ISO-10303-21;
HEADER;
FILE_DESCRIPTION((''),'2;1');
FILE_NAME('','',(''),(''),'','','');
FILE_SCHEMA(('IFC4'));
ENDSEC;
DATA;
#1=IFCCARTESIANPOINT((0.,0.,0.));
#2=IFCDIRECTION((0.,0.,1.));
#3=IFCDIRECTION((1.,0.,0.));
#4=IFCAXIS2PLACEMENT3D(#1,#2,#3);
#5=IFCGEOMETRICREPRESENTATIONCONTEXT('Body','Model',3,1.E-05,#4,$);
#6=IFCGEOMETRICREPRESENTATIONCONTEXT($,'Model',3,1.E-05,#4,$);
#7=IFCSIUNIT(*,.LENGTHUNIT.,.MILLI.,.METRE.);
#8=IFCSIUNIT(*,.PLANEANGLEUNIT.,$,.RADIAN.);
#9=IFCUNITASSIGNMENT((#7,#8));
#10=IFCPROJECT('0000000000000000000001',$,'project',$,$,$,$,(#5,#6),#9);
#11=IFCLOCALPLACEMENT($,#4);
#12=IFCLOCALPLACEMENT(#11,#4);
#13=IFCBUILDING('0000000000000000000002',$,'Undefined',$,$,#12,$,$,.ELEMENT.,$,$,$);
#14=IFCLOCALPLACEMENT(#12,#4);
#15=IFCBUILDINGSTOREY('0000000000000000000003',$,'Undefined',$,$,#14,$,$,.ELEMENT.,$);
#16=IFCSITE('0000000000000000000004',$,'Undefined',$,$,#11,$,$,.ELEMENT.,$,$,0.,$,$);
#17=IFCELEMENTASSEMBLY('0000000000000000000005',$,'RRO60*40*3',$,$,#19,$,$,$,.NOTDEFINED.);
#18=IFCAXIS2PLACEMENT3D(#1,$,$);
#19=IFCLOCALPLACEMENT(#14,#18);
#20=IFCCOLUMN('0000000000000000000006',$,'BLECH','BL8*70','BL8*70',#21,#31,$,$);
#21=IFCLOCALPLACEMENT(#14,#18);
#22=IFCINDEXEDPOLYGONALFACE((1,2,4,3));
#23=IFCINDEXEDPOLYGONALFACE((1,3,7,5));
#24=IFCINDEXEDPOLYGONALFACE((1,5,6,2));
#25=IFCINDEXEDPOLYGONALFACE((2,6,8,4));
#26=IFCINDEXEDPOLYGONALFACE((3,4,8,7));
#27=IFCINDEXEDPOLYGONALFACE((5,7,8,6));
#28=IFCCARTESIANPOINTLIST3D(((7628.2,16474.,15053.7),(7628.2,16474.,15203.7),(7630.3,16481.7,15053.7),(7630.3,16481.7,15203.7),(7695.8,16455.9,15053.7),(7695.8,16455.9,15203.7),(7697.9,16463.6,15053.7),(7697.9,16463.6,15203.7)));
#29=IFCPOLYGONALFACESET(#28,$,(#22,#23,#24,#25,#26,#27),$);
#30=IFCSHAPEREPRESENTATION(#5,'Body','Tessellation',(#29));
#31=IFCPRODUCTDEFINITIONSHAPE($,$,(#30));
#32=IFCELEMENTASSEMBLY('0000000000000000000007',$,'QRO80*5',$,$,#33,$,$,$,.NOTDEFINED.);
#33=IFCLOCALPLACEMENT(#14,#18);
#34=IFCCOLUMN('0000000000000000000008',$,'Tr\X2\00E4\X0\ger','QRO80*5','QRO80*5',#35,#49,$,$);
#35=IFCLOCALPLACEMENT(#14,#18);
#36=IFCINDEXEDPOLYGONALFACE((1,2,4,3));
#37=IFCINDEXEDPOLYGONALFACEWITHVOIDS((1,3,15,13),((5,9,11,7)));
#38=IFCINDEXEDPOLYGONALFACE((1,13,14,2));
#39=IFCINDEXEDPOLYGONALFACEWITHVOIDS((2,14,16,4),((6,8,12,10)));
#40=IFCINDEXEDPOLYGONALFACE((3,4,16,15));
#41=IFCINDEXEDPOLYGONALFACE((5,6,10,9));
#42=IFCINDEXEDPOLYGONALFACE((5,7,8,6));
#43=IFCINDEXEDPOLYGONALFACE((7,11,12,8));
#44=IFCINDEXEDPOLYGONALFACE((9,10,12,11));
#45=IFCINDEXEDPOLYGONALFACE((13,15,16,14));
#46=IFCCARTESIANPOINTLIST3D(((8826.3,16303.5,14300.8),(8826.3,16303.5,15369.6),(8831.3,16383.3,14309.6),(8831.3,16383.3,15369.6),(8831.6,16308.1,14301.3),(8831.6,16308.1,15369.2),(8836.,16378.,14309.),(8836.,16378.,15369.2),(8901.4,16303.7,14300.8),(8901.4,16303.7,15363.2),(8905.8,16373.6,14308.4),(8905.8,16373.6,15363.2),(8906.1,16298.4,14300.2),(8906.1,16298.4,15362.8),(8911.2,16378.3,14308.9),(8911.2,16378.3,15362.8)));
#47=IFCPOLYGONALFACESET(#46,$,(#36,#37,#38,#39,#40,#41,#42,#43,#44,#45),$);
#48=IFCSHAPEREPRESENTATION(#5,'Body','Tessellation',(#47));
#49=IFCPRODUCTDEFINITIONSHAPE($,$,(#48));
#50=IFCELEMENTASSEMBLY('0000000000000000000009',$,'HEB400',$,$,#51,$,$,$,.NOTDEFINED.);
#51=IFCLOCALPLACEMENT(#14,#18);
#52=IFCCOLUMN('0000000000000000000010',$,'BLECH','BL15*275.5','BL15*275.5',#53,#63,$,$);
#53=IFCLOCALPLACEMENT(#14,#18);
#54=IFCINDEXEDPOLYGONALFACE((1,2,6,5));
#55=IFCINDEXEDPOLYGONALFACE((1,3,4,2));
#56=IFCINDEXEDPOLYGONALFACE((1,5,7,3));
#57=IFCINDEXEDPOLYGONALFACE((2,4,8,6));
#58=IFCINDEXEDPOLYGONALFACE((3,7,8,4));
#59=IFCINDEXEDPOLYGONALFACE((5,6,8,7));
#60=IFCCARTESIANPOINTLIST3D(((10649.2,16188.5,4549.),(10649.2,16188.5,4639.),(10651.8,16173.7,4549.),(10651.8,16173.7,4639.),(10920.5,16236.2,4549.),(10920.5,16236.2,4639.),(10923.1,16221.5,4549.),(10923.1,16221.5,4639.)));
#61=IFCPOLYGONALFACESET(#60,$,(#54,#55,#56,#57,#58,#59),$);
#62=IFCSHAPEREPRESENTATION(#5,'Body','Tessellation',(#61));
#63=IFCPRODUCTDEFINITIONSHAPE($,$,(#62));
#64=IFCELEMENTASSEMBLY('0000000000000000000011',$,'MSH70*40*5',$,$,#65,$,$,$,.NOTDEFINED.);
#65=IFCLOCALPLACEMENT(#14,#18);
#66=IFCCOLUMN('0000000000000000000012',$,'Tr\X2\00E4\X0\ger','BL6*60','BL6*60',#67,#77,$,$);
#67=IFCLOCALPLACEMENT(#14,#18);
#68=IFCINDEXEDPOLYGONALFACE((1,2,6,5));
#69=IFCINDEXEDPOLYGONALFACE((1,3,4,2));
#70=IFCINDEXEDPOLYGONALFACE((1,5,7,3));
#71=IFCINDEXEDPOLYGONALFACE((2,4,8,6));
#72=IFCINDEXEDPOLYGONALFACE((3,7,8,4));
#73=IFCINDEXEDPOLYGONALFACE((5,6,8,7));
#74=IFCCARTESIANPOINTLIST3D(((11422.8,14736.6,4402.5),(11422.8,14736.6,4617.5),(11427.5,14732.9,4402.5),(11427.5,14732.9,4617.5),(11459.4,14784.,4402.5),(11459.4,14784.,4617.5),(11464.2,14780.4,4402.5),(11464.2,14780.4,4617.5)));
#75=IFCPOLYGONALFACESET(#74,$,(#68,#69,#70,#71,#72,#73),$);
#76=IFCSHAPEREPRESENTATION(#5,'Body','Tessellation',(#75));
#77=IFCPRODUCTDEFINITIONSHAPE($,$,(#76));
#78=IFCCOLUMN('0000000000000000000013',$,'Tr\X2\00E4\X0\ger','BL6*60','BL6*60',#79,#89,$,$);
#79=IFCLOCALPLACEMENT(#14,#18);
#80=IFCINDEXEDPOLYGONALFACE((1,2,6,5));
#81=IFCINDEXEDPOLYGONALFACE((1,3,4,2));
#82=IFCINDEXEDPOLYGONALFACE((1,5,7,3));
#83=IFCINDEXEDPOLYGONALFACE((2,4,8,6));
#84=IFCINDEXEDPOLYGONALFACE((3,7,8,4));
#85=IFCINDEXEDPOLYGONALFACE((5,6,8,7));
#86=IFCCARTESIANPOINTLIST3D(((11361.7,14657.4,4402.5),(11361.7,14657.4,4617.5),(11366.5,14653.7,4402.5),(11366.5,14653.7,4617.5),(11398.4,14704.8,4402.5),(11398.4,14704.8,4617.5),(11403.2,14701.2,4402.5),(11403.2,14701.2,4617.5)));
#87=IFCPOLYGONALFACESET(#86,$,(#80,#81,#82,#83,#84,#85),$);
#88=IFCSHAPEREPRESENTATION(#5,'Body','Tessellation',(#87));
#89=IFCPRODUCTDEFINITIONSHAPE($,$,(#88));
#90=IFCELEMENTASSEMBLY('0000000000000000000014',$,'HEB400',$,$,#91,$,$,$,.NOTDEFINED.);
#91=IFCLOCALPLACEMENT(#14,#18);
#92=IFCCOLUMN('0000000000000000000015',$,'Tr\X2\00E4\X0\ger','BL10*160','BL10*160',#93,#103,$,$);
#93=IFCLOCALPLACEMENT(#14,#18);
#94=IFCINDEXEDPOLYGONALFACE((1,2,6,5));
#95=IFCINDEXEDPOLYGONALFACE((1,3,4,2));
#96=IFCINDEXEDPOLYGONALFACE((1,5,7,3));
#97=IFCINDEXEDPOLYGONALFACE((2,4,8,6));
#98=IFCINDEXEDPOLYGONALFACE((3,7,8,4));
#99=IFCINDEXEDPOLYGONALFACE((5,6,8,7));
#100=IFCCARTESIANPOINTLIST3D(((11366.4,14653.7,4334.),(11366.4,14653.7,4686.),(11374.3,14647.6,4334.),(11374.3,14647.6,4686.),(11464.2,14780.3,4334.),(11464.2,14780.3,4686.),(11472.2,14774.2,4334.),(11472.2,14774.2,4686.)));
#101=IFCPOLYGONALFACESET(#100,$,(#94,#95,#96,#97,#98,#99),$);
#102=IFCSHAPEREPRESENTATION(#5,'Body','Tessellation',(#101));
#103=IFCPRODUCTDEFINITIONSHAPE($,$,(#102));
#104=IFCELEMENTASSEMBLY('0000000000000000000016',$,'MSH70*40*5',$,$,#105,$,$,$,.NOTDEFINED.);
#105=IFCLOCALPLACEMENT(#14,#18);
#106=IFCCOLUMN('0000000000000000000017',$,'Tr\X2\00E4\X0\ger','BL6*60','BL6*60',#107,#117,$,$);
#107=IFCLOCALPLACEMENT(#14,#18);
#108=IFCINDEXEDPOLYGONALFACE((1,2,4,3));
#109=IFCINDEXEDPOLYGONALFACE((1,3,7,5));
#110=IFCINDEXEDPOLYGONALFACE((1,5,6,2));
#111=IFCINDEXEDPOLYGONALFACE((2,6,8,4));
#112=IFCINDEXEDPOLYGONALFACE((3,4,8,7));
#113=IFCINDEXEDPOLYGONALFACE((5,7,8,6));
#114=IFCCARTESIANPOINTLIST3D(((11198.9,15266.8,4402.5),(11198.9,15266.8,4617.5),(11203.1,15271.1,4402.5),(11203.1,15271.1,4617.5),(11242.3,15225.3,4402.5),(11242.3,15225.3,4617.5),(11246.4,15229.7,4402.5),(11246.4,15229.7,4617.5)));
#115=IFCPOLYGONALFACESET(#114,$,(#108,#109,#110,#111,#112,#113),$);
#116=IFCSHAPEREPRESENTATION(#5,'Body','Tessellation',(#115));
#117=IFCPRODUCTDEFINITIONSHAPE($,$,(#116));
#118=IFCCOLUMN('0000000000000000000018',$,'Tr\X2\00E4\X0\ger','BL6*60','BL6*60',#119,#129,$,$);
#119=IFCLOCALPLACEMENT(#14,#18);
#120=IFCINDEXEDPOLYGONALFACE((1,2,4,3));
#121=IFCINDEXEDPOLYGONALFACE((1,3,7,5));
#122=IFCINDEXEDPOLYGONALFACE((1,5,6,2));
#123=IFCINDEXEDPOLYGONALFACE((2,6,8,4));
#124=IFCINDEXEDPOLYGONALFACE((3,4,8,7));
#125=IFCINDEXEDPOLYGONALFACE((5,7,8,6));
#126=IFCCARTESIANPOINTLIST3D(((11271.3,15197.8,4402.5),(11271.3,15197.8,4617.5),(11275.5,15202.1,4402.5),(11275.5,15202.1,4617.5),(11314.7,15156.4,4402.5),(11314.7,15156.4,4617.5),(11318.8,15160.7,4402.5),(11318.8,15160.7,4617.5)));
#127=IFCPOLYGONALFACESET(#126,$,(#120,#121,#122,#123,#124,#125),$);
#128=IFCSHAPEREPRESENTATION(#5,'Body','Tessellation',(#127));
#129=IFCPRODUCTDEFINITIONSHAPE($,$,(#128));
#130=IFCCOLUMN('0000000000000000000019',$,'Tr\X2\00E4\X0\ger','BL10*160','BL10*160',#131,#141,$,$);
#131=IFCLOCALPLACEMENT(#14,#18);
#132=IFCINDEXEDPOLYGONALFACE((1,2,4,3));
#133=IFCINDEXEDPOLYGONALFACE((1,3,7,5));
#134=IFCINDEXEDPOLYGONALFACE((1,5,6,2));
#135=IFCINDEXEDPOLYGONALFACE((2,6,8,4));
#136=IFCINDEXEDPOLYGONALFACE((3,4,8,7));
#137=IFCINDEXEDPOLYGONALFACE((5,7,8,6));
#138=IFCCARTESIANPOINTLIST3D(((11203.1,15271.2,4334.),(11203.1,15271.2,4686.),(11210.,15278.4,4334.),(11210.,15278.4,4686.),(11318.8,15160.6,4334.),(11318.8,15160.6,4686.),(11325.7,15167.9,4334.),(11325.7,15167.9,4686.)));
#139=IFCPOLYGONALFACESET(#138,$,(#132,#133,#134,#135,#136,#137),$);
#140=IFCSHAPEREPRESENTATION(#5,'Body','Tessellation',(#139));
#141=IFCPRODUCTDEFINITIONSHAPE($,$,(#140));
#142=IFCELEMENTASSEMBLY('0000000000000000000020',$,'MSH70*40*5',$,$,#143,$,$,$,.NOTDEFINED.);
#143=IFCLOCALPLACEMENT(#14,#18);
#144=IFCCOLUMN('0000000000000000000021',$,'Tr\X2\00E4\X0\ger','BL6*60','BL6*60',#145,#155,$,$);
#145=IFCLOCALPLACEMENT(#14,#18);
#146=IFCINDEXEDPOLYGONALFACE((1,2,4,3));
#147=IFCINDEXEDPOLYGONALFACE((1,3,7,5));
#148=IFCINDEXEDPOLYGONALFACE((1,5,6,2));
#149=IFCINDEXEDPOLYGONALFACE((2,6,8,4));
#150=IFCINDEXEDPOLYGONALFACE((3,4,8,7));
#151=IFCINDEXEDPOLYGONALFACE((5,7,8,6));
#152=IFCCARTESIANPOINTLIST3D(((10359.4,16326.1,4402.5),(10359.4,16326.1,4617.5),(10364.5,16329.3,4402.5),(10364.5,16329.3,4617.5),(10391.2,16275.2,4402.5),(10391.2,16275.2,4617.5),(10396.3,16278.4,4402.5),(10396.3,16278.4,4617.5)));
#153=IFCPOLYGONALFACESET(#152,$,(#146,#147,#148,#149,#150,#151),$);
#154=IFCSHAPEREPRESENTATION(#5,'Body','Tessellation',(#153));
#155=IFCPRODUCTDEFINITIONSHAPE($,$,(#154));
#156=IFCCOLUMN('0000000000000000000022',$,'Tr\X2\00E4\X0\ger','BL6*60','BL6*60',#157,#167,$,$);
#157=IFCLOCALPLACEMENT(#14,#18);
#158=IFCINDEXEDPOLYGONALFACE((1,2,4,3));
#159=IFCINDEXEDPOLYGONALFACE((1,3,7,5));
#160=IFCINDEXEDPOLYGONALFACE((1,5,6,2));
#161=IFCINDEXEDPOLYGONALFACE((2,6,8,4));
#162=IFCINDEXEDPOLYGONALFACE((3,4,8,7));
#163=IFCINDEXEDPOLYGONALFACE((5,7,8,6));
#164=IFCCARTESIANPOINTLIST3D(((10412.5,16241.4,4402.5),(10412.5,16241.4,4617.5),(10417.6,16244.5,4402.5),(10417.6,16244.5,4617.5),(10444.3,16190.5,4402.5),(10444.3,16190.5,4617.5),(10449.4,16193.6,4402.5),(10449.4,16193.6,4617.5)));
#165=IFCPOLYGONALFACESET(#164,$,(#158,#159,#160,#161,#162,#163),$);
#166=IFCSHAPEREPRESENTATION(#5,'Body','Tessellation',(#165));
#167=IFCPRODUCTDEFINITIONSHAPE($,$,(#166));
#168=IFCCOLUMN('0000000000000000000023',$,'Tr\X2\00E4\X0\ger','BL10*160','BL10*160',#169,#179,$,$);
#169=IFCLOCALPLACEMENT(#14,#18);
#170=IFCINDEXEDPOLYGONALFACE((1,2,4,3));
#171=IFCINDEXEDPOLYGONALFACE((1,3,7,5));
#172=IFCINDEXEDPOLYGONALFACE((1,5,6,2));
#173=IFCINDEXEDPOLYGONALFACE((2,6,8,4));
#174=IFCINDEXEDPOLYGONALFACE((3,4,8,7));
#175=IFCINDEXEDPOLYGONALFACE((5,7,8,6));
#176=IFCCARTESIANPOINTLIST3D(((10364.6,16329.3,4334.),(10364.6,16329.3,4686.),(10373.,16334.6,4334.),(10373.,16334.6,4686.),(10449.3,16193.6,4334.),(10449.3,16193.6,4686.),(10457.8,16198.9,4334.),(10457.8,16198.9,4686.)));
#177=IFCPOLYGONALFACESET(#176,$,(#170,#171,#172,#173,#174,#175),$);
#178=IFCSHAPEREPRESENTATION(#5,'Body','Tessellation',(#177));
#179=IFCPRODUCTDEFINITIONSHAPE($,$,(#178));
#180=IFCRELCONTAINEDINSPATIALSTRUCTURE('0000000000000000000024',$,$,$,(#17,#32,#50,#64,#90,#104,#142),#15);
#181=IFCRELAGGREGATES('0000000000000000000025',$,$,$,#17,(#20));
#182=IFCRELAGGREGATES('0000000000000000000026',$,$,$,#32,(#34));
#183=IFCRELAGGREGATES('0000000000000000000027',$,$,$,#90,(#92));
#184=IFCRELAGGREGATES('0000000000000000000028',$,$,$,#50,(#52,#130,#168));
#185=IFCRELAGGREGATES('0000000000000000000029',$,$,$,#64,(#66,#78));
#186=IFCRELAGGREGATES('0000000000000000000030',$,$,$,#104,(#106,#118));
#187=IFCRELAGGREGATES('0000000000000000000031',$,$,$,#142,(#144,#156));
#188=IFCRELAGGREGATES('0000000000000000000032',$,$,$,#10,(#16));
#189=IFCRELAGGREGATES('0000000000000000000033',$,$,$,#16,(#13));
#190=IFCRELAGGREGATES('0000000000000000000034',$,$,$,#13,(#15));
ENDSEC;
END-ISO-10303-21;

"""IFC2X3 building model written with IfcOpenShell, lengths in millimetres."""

from ifc_helpers import new_model, si_unit, frame, origin_with_axes, origin_2d_with_axis, place, context, project, spatial, rectangle, hollow_rectangle, extrude, clip, halfspace, element, aggregate, save


model = new_model("IFC2X3")

# Units and contexts
model_context_1 = context("Model", 3, precision=1e-05, world=origin_with_axes(), identifier="Body")
model_context_2 = context("Model", 3, precision=1e-05, world=origin_with_axes())
ifc_project = project(units=[si_unit("LENGTHUNIT", "METRE", prefix="MILLI"), si_unit("PLANEANGLEUNIT", "RADIAN")], contexts=[model_context_1, model_context_2])

# Site, building, storey
site_placement = place(None, origin_with_axes())
site = spatial("IfcSite", under=ifc_project, at=site_placement, Name="Undefined", CompositionType="ELEMENT", RefElevation=0.0)
building_placement = place(site_placement, origin_with_axes())
building = spatial("IfcBuilding", under=site, at=building_placement, Name="Undefined", CompositionType="ELEMENT")
storey_placement = place(building_placement, origin_with_axes())
storey = spatial("IfcBuildingStorey", under=building, at=storey_placement, Name="Undefined", CompositionType="ELEMENT")

# Element assemblies, columns
assembly_1 = element("IfcElementAssembly", 1, inside=storey, Name="RRO60*40*3", PredefinedType="NOTDEFINED")
column_1_placement = place(storey_placement, frame((7663.1, 16468.8, 15053.7), z_axis=(0.0, 0.0, 1.0), x_axis=(1.0, 0.0, 0.0)))
column_1 = element("IfcColumn", 2, at=column_1_placement, Name="BLECH", Description="BL8*70", ObjectType="BL8*70", context=model_context_1, shape_type="SweptSolid", body=[
    extrude(rectangle(XDim=8.0, YDim=70.0, at=origin_2d_with_axis()), frame((0.0, 0.0, 150.0), z_axis=(0.0, 0.0, -1.0), x_axis=(0.259213, 0.96582, 0.000005)), (0.0, 0.0, 1.0), 150.0),
])
aggregate(assembly_1, [column_1])
assembly_2 = element("IfcElementAssembly", 3, inside=storey, Name="QRO80*5", PredefinedType="NOTDEFINED")
column_2_placement = place(storey_placement, frame((8868.7, 16340.9, 14474.9), z_axis=(0.0, 0.0, 1.0), x_axis=(1.0, 0.0, 0.0)))
column_2 = element("IfcColumn", 4, at=column_2_placement, Name="Träger", Description="QRO80*5", ObjectType="QRO80*5", context=model_context_1, shape_type="Clipping", body=[
    clip(clip(extrude(hollow_rectangle(XDim=80.0, YDim=80.0, WallThickness=5.0, at=origin_2d_with_axis()), frame((0.0, 0.0, 899.4), z_axis=(0.0, 0.0, -1.0), x_axis=(0.998019, -0.06291, -0.000001)), (0.0, 0.0, 1.0), 1077.7), halfspace(frame((39.9, -2.5, -170.4), z_axis=(0.001304, -0.108856, 0.994057), x_axis=(-0.063857, -0.992038, -0.108551)), True)), halfspace(frame((-2.5, -39.9, 891.2), z_axis=(-0.084763, 0.005352, -0.996387), x_axis=(0.994413, -0.062691, -0.084932)), True)),
])
aggregate(assembly_2, [column_2])
assembly_3 = element("IfcElementAssembly", 5, inside=storey, Name="HEB400", PredefinedType="NOTDEFINED")
column_3_placement = place(storey_placement, frame((10786.2, 16205.0, 4549.0), z_axis=(0.0, 0.0, 1.0), x_axis=(1.0, 0.0, 0.0)))
column_3 = element("IfcColumn", 6, at=column_3_placement, Name="BLECH", Description="BL15*275.5", ObjectType="BL15*275.5", context=model_context_1, shape_type="SweptSolid", body=[
    extrude(rectangle(XDim=15.0, YDim=275.5, at=origin_2d_with_axis()), frame((0.0, 0.0, 90.0), z_axis=(0.0, 0.0, -1.0), x_axis=(0.173304, -0.984868, 0.0)), (0.0, 0.0, 1.0), 90.0),
])

# Element assembly, columns
assembly_4 = element("IfcElementAssembly", 7, inside=storey, Name="MSH70*40*5", PredefinedType="NOTDEFINED")
column_4_placement = place(storey_placement, frame((11443.5, 14758.5, 4402.5), z_axis=(0.0, 0.0, 1.0), x_axis=(1.0, 0.0, 0.0)))
column_4 = element("IfcColumn", 8, at=column_4_placement, Name="Träger", Description="BL6*60", ObjectType="BL6*60", context=model_context_1, shape_type="SweptSolid", body=[
    extrude(rectangle(XDim=6.0, YDim=60.0, at=origin_2d_with_axis()), frame((0.0, 0.0, 215.0), z_axis=(0.0, 0.0, -1.0), x_axis=(-0.791223, 0.611527, 0.0)), (0.0, 0.0, 1.0), 215.0),
])
column_5_placement = place(storey_placement, frame((11382.4, 14679.3, 4402.5), z_axis=(0.0, 0.0, 1.0), x_axis=(1.0, 0.0, 0.0)))
column_5 = element("IfcColumn", 9, at=column_5_placement, Name="Träger", Description="BL6*60", ObjectType="BL6*60", context=model_context_1, shape_type="SweptSolid", body=[
    extrude(rectangle(XDim=6.0, YDim=60.0, at=origin_2d_with_axis()), frame((0.0, 0.0, 215.0), z_axis=(0.0, 0.0, -1.0), x_axis=(-0.791223, 0.611527, 0.0)), (0.0, 0.0, 1.0), 215.0),
])

# Element assembly, column
assembly_5 = element("IfcElementAssembly", 10, inside=storey, Name="HEB400", PredefinedType="NOTDEFINED")
column_6_placement = place(storey_placement, frame((11419.3, 14714.0, 4334.0), z_axis=(0.0, 0.0, 1.0), x_axis=(1.0, 0.0, 0.0)))
column_6 = element("IfcColumn", 11, at=column_6_placement, Name="Träger", Description="BL10*160", ObjectType="BL10*160", context=model_context_1, shape_type="SweptSolid", body=[
    extrude(rectangle(XDim=10.0, YDim=160.0, at=origin_2d_with_axis()), frame((0.0, 0.0, 352.0), z_axis=(0.0, 0.0, -1.0), x_axis=(-0.791223, 0.611527, 0.0)), (0.0, 0.0, 1.0), 352.0),
])
aggregate(assembly_5, [column_6])

# Element assembly, columns
assembly_6 = element("IfcElementAssembly", 12, inside=storey, Name="MSH70*40*5", PredefinedType="NOTDEFINED")
column_7_placement = place(storey_placement, frame((11222.7, 15248.2, 4402.5), z_axis=(0.0, 0.0, 1.0), x_axis=(1.0, 0.0, 0.0)))
column_7 = element("IfcColumn", 13, at=column_7_placement, Name="Träger", Description="BL6*60", ObjectType="BL6*60", context=model_context_1, shape_type="SweptSolid", body=[
    extrude(rectangle(XDim=6.0, YDim=60.0, at=origin_2d_with_axis()), frame((0.0, 0.0, 215.0), z_axis=(0.0, 0.0, -1.0), x_axis=(-0.690883, -0.722967, 0.0)), (0.0, 0.0, 1.0), 215.0),
])
column_8_placement = place(storey_placement, frame((11295.1, 15179.2, 4402.5), z_axis=(0.0, 0.0, 1.0), x_axis=(1.0, 0.0, 0.0)))
column_8 = element("IfcColumn", 14, at=column_8_placement, Name="Träger", Description="BL6*60", ObjectType="BL6*60", context=model_context_1, shape_type="SweptSolid", body=[
    extrude(rectangle(XDim=6.0, YDim=60.0, at=origin_2d_with_axis()), frame((0.0, 0.0, 215.0), z_axis=(0.0, 0.0, -1.0), x_axis=(-0.690883, -0.722967, 0.0)), (0.0, 0.0, 1.0), 215.0),
])

# Column
column_9_placement = place(storey_placement, frame((11264.4, 15219.5, 4334.0), z_axis=(0.0, 0.0, 1.0), x_axis=(1.0, 0.0, 0.0)))
column_9 = element("IfcColumn", 15, at=column_9_placement, Name="Träger", Description="BL10*160", ObjectType="BL10*160", context=model_context_1, shape_type="SweptSolid", body=[
    extrude(rectangle(XDim=10.0, YDim=160.0, at=origin_2d_with_axis()), frame((0.0, 0.0, 352.0), z_axis=(0.0, 0.0, -1.0), x_axis=(-0.690883, -0.722967, 0.0)), (0.0, 0.0, 1.0), 352.0),
])

# Element assembly, columns
assembly_7 = element("IfcElementAssembly", 16, inside=storey, Name="MSH70*40*5", PredefinedType="NOTDEFINED")
column_10_placement = place(storey_placement, frame((10377.8, 16302.2, 4402.5), z_axis=(0.0, 0.0, 1.0), x_axis=(1.0, 0.0, 0.0)))
column_10 = element("IfcColumn", 17, at=column_10_placement, Name="Träger", Description="BL6*60", ObjectType="BL6*60", context=model_context_1, shape_type="SweptSolid", body=[
    extrude(rectangle(XDim=6.0, YDim=60.0, at=origin_2d_with_axis()), frame((0.0, 0.0, 215.0), z_axis=(0.0, 0.0, -1.0), x_axis=(-0.848048, -0.529919, 0.0)), (0.0, 0.0, 1.0), 215.0),
])
column_11_placement = place(storey_placement, frame((10431.0, 16217.5, 4402.5), z_axis=(0.0, 0.0, 1.0), x_axis=(1.0, 0.0, 0.0)))
column_11 = element("IfcColumn", 18, at=column_11_placement, Name="Träger", Description="BL6*60", ObjectType="BL6*60", context=model_context_1, shape_type="SweptSolid", body=[
    extrude(rectangle(XDim=6.0, YDim=60.0, at=origin_2d_with_axis()), frame((0.0, 0.0, 215.0), z_axis=(0.0, 0.0, -1.0), x_axis=(-0.848048, -0.529919, 0.0)), (0.0, 0.0, 1.0), 215.0),
])

# Column
column_12_placement = place(storey_placement, frame((10411.2, 16264.1, 4334.0), z_axis=(0.0, 0.0, 1.0), x_axis=(1.0, 0.0, 0.0)))
column_12 = element("IfcColumn", 19, at=column_12_placement, Name="Träger", Description="BL10*160", ObjectType="BL10*160", context=model_context_1, shape_type="SweptSolid", body=[
    extrude(rectangle(XDim=10.0, YDim=160.0, at=origin_2d_with_axis()), frame((0.0, 0.0, 352.0), z_axis=(0.0, 0.0, -1.0), x_axis=(-0.848048, -0.529919, 0.0)), (0.0, 0.0, 1.0), 352.0),
])
aggregate(assembly_3, [column_3, column_9, column_12])
aggregate(assembly_4, [column_4, column_5])
aggregate(assembly_6, [column_7, column_8])
aggregate(assembly_7, [column_10, column_11])

save(model, "model.ifc")
